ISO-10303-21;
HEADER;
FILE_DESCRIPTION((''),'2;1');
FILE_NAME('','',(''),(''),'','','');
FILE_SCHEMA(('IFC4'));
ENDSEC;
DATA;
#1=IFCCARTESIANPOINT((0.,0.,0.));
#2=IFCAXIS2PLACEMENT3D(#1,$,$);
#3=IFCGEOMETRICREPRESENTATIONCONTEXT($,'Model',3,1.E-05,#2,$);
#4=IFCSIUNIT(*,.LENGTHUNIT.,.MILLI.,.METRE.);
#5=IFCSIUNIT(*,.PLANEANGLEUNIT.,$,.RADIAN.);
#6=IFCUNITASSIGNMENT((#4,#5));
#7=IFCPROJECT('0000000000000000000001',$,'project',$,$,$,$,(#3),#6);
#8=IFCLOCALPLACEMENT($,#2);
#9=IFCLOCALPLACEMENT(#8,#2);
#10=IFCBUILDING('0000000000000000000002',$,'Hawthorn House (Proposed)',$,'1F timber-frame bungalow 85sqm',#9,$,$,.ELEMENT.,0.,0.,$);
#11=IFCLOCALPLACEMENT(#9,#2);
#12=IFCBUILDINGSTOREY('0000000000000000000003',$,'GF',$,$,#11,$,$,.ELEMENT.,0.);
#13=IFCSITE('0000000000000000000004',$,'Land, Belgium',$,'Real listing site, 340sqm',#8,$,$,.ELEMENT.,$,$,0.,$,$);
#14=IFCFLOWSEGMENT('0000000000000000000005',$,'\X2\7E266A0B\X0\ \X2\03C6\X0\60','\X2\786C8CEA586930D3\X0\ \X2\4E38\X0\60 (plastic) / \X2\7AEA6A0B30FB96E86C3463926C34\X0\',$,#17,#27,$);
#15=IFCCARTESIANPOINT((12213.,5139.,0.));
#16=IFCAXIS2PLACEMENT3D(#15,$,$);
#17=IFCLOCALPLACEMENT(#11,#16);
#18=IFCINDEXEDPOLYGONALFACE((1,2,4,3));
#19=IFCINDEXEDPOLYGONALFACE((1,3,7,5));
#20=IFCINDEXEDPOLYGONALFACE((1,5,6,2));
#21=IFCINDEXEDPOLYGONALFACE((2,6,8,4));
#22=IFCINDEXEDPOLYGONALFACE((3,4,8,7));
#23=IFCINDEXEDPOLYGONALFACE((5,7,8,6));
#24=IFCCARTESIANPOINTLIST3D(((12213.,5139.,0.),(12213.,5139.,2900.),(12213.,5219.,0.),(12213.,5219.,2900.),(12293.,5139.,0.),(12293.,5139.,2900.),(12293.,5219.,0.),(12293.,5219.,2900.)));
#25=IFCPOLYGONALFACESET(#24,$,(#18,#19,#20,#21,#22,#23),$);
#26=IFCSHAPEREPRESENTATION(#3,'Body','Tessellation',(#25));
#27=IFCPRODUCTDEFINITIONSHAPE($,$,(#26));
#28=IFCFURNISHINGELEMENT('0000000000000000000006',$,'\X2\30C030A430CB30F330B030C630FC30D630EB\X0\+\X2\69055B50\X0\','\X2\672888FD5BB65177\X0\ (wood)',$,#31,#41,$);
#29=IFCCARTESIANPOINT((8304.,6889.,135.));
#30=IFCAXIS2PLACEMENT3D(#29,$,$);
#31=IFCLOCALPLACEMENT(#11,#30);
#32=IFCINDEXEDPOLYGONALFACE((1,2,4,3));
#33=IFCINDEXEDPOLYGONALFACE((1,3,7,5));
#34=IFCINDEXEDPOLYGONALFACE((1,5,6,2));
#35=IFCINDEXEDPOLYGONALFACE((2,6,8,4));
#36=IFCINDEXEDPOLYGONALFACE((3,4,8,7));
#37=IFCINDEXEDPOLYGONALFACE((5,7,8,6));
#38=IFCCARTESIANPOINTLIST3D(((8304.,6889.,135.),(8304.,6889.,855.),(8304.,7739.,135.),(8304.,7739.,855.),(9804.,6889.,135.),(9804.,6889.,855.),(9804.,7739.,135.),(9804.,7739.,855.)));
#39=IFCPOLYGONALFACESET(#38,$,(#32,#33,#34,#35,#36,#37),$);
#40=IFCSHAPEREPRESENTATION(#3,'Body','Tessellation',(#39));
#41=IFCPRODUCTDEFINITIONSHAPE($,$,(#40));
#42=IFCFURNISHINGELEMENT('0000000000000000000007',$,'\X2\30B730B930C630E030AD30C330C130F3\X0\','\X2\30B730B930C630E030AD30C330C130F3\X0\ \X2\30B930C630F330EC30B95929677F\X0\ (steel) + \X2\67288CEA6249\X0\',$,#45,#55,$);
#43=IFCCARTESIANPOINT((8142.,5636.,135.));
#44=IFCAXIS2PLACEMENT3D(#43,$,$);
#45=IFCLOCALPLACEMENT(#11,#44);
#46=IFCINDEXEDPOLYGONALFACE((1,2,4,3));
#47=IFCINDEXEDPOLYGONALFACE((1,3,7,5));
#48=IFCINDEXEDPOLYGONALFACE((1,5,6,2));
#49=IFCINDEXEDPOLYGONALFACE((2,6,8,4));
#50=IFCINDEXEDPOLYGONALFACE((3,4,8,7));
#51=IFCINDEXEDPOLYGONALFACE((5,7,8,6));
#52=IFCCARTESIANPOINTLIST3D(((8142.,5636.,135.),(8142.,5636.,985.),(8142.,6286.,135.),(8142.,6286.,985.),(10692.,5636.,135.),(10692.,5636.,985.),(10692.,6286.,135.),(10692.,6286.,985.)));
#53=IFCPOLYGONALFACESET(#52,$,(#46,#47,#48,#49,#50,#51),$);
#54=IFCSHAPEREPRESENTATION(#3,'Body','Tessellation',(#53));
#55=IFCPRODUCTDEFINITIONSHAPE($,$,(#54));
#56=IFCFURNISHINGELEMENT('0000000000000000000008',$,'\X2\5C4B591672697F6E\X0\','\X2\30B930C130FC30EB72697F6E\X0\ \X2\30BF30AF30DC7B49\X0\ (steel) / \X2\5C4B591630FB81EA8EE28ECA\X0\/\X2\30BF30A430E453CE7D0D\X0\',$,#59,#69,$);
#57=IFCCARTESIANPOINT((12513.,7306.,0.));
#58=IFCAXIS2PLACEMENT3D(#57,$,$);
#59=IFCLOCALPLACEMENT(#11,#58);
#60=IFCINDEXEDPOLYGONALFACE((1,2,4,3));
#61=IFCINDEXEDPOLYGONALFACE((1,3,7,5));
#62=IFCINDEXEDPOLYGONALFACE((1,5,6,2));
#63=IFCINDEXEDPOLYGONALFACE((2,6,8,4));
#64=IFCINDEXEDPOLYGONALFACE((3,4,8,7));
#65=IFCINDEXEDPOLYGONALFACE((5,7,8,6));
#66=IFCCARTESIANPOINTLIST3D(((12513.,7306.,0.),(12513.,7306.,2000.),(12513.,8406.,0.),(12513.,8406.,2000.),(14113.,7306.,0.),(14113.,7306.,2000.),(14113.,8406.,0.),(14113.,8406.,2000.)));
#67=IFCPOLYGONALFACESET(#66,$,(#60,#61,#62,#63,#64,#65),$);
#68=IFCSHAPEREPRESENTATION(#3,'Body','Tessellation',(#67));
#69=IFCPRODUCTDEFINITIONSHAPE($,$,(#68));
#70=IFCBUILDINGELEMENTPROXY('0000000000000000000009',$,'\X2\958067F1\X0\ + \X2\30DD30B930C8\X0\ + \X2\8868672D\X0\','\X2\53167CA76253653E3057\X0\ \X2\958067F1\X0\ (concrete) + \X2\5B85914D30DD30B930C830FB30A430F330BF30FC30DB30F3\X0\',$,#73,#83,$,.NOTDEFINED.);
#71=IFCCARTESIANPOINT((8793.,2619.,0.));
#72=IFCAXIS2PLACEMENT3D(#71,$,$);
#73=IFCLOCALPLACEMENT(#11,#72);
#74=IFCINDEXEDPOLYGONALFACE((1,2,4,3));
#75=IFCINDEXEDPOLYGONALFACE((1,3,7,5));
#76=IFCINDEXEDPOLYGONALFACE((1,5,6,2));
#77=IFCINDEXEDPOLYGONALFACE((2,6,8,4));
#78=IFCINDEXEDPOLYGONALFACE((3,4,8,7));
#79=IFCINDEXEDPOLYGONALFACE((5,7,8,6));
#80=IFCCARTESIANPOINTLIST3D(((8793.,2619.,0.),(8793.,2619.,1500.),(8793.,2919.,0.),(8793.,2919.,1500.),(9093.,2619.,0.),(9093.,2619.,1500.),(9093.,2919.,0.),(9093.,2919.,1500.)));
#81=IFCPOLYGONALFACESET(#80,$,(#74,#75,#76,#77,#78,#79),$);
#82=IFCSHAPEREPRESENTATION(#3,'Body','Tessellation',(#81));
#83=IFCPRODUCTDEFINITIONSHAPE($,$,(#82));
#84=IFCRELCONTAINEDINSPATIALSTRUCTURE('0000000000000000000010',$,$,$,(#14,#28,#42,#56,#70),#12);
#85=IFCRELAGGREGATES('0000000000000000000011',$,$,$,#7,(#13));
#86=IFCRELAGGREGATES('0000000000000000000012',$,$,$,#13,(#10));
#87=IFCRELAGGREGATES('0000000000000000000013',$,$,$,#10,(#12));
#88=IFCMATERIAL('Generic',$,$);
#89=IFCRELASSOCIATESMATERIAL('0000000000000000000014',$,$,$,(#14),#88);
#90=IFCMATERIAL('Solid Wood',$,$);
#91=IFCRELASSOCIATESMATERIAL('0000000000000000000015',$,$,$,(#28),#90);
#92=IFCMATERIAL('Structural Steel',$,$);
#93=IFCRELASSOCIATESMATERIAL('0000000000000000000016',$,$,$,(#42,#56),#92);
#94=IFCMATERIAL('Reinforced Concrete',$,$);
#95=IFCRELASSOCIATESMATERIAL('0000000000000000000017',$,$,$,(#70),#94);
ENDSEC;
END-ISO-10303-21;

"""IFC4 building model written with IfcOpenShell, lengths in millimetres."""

from ifc_helpers import new_model, si_unit, frame, frame_2d, origin, place, context, project, spatial, rectangle, extrude, material, element, save


model = new_model("IFC4")

# Units and contexts
model_context = context("Model", 3, precision=1e-05, world=origin())
ifc_project = project(units=[si_unit("LENGTHUNIT", "METRE", prefix="MILLI"), si_unit("PLANEANGLEUNIT", "RADIAN")], contexts=[model_context])

# Site, building, storey
site_placement = place(None, origin())
site = spatial("IfcSite", under=ifc_project, at=site_placement, Name="Land, Belgium", ObjectType="Real listing site, 340sqm", CompositionType="ELEMENT", RefElevation=0.0)
building_placement = place(site_placement, origin())
building = spatial("IfcBuilding", under=site, at=building_placement, Name="Hawthorn House (Proposed)", ObjectType="1F timber-frame bungalow 85sqm", CompositionType="ELEMENT", ElevationOfRefHeight=0.0, ElevationOfTerrain=0.0)
storey_placement = place(building_placement, origin())
storey = spatial("IfcBuildingStorey", under=building, at=storey_placement, Name="GF", CompositionType="ELEMENT", Elevation=0.0)

# Shared definitions
ifc_material_1 = material(Name="Solid Wood")

# Shared definitions
ifc_material_2 = material(Name="Structural Steel")

# Shared definitions
ifc_material_3 = material(Name="Reinforced Concrete")

# Shared definitions
ifc_material_4 = material(Name="Generic")

# Flow segment
flow_segment_placement = place(storey_placement, frame((12213.0, 5139.0, 0.0)))
element("IfcFlowSegment", 1, at=flow_segment_placement, inside=storey, material=ifc_material_4, Name="縦樋 φ60", Description="硬質塩ビ 丸60 (plastic) / 竪樋・雨水排水", context=model_context, shape_type="SweptSolid", body=[
    extrude(rectangle(XDim=80.0, YDim=80.0, at=frame_2d((40.0, 40.0))), frame((12213.0, 5139.0, 0.0)), (0.0, 0.0, 1.0), 2900.0),
])

# Furnishing elements
furnishing_1_placement = place(storey_placement, frame((8304.0, 6889.0, 135.0)))
element("IfcFurnishingElement", 2, at=furnishing_1_placement, inside=storey, material=ifc_material_1, Name="ダイニングテーブル+椅子", Description="木製家具 (wood)", context=model_context, shape_type="SweptSolid", body=[
    extrude(rectangle(XDim=1500.0, YDim=850.0, at=frame_2d((750.0, 425.0))), frame((8304.0, 6889.0, 135.0)), (0.0, 0.0, 1.0), 720.0),
])
furnishing_2_placement = place(storey_placement, frame((8142.0, 5636.0, 135.0)))
element("IfcFurnishingElement", 3, at=furnishing_2_placement, inside=storey, material=ifc_material_2, Name="システムキッチン", Description="システムキッチン ステンレス天板 (steel) + 木質扉", context=model_context, shape_type="SweptSolid", body=[
    extrude(rectangle(XDim=2550.0, YDim=650.0, at=frame_2d((1275.0, 325.0))), frame((8142.0, 5636.0, 135.0)), (0.0, 0.0, 1.0), 850.0),
])
furnishing_3_placement = place(storey_placement, frame((12513.0, 7306.0, 0.0)))
element("IfcFurnishingElement", 4, at=furnishing_3_placement, inside=storey, material=ifc_material_2, Name="屋外物置", Description="スチール物置 タクボ等 (steel) / 屋外・自転車/タイヤ収納", context=model_context, shape_type="SweptSolid", body=[
    extrude(rectangle(XDim=1600.0, YDim=1100.0, at=frame_2d((800.0, 550.0))), frame((12513.0, 7306.0, 0.0)), (0.0, 0.0, 1.0), 2000.0),
])

# Building element proxy
proxy_placement = place(storey_placement, frame((8793.0, 2619.0, 0.0)))
element("IfcBuildingElementProxy", 5, at=proxy_placement, inside=storey, material=ifc_material_3, Name="門柱 + ポスト + 表札", Description="化粧打放し 門柱 (concrete) + 宅配ポスト・インターホン", PredefinedType="NOTDEFINED", context=model_context, shape_type="SweptSolid", body=[
    extrude(rectangle(XDim=300.0, YDim=300.0, at=frame_2d((150.0, 150.0))), frame((8793.0, 2619.0, 0.0)), (0.0, 0.0, 1.0), 1500.0),
])

save(model, "model.ifc")
